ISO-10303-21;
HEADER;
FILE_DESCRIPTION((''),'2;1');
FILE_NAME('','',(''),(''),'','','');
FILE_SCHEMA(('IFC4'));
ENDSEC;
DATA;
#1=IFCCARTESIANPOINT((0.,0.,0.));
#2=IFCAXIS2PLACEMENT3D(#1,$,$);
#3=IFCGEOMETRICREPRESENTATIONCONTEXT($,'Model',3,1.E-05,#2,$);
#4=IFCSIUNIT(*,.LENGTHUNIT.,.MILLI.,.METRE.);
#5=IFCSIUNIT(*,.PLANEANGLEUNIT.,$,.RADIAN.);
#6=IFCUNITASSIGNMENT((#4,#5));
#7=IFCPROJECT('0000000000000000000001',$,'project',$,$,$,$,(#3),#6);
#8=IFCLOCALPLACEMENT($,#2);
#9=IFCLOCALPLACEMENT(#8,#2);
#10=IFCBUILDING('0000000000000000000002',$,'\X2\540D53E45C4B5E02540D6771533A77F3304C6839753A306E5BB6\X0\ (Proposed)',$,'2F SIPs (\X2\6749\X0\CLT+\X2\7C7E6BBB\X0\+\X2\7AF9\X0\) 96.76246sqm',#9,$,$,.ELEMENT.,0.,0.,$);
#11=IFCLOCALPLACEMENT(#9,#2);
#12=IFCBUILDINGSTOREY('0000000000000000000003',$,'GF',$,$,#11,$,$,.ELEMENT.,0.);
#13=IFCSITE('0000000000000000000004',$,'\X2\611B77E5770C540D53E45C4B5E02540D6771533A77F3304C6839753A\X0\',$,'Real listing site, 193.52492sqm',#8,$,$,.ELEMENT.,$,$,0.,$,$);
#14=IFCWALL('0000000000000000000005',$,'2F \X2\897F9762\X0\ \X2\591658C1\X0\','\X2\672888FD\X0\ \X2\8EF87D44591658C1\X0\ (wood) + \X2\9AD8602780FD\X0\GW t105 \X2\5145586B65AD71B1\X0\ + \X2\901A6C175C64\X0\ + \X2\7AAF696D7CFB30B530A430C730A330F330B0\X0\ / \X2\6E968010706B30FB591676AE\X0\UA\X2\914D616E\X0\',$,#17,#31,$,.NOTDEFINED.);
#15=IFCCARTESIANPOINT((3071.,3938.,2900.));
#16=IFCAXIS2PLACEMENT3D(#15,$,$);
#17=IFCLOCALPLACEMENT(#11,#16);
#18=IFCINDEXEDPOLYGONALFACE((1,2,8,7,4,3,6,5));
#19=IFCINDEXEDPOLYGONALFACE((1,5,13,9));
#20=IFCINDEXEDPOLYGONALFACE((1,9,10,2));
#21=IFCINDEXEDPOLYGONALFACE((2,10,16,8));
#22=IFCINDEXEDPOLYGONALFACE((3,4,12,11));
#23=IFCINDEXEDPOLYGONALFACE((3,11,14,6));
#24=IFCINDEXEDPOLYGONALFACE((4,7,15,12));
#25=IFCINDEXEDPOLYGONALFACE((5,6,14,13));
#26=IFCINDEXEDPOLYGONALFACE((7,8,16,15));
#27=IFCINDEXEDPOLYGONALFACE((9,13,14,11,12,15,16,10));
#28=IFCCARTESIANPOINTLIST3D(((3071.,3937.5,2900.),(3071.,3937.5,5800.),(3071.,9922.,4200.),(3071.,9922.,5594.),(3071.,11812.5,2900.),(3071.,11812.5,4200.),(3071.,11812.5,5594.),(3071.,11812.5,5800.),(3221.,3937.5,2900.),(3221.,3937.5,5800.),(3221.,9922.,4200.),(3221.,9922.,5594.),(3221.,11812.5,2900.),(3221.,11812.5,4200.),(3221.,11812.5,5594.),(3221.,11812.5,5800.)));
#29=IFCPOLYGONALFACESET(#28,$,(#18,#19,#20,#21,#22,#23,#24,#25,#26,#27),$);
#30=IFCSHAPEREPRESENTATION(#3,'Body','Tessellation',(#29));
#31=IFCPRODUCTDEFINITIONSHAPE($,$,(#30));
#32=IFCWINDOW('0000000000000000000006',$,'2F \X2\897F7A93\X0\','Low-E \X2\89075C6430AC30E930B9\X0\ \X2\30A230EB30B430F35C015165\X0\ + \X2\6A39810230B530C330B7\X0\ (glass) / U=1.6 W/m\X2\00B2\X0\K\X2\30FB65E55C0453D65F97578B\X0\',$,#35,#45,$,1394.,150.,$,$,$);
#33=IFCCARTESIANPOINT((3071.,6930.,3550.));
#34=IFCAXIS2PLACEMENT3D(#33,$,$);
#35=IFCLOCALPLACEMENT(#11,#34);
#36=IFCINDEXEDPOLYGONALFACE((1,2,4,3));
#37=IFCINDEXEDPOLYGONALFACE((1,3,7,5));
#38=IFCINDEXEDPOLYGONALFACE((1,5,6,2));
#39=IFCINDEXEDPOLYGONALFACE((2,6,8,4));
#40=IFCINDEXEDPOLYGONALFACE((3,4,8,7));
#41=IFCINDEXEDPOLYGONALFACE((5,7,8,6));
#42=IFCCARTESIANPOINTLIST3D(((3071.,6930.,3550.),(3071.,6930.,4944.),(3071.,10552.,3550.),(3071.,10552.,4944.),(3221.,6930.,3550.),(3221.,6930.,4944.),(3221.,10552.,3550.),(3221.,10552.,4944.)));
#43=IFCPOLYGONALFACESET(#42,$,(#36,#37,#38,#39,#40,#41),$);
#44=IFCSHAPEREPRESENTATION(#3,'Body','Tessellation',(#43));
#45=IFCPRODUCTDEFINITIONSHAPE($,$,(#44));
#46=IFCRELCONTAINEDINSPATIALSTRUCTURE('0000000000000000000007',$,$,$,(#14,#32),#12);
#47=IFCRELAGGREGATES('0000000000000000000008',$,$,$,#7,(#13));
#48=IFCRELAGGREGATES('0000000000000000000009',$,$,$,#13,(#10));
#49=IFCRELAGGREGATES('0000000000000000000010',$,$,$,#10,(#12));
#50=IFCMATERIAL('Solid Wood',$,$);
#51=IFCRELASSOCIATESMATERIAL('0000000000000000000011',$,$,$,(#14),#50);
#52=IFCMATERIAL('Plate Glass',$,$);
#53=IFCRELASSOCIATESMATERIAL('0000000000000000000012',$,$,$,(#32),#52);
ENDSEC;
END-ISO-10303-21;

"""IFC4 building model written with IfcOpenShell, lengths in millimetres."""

from ifc_helpers import new_model, si_unit, frame, frame_2d, origin, place, context, project, spatial, rectangle, extrude, material, element, fill, save


model = new_model("IFC4")

# Units and contexts
model_context = context("Model", 3, precision=1e-05, world=origin())
ifc_project = project(units=[si_unit("LENGTHUNIT", "METRE", prefix="MILLI"), si_unit("PLANEANGLEUNIT", "RADIAN")], contexts=[model_context])

# Site, building, storey
site_placement = place(None, origin())
site = spatial("IfcSite", under=ifc_project, at=site_placement, Name="愛知県名古屋市名東区石が根町", ObjectType="Real listing site, 193.52492sqm", CompositionType="ELEMENT", RefElevation=0.0)
building_placement = place(site_placement, origin())
building = spatial("IfcBuilding", under=site, at=building_placement, Name="名古屋市名東区石が根町の家 (Proposed)", ObjectType="2F SIPs (杉CLT+籾殻+竹) 96.76246sqm", CompositionType="ELEMENT", ElevationOfRefHeight=0.0, ElevationOfTerrain=0.0)
storey_placement = place(building_placement, origin())
storey = spatial("IfcBuildingStorey", under=building, at=storey_placement, Name="GF", CompositionType="ELEMENT", Elevation=0.0)

# Shared definitions
ifc_material_1 = material(Name="Solid Wood")

# Shared definitions
ifc_material_2 = material(Name="Plate Glass")

# Wall, opening, window
wall_1_placement = place(storey_placement, frame((3071.0, 3938.0, 2900.0)))
wall_1 = element("IfcWall", 1, at=wall_1_placement, inside=storey, material=ifc_material_1, Name="2F 西面 外壁", Description="木製 軸組外壁 (wood) + 高性能GW t105 充填断熱 + 通気層 + 窯業系サイディング / 準耐火・外皮UA配慮", PredefinedType="NOTDEFINED", context=model_context, shape_type="SweptSolid", body=[
    extrude(rectangle(XDim=150.0, YDim=7875.0, at=frame_2d((75.0, 3937.0))), frame((3071.0, 3938.0, 2900.0)), (0.0, 0.0, 1.0), 2900.0),
])
opening_1_placement = place(storey_placement, frame((3071.0, 6930.0, 3550.0)))
opening_1 = element("IfcOpeningElement", 2, at=opening_1_placement, cuts=wall_1, PredefinedType="NOTDEFINED", context=model_context, shape_type="SweptSolid", body=[
    extrude(rectangle(XDim=150.0, YDim=3622.0, at=frame_2d((75.0, 1811.0))), frame((3071.0, 6930.0, 3550.0)), (0.0, 0.0, 1.0), 1394.0),
])
window_1_placement = place(storey_placement, frame((3071.0, 6930.0, 3550.0)))
window_1 = element("IfcWindow", 3, at=window_1_placement, inside=storey, material=ifc_material_2, Name="2F 西窓", Description="Low-E 複層ガラス アルゴン封入 + 樹脂サッシ (glass) / U=1.6 W/m²K・日射取得型", OverallHeight=1394.0, OverallWidth=150.0, context=model_context, shape_type="SweptSolid", body=[
    extrude(rectangle(XDim=150.0, YDim=3622.0, at=frame_2d((75.0, 1811.0))), frame((3071.0, 6930.0, 3550.0)), (0.0, 0.0, 1.0), 1394.0),
])
fill(opening_1, window_1)

save(model, "model.ifc")
